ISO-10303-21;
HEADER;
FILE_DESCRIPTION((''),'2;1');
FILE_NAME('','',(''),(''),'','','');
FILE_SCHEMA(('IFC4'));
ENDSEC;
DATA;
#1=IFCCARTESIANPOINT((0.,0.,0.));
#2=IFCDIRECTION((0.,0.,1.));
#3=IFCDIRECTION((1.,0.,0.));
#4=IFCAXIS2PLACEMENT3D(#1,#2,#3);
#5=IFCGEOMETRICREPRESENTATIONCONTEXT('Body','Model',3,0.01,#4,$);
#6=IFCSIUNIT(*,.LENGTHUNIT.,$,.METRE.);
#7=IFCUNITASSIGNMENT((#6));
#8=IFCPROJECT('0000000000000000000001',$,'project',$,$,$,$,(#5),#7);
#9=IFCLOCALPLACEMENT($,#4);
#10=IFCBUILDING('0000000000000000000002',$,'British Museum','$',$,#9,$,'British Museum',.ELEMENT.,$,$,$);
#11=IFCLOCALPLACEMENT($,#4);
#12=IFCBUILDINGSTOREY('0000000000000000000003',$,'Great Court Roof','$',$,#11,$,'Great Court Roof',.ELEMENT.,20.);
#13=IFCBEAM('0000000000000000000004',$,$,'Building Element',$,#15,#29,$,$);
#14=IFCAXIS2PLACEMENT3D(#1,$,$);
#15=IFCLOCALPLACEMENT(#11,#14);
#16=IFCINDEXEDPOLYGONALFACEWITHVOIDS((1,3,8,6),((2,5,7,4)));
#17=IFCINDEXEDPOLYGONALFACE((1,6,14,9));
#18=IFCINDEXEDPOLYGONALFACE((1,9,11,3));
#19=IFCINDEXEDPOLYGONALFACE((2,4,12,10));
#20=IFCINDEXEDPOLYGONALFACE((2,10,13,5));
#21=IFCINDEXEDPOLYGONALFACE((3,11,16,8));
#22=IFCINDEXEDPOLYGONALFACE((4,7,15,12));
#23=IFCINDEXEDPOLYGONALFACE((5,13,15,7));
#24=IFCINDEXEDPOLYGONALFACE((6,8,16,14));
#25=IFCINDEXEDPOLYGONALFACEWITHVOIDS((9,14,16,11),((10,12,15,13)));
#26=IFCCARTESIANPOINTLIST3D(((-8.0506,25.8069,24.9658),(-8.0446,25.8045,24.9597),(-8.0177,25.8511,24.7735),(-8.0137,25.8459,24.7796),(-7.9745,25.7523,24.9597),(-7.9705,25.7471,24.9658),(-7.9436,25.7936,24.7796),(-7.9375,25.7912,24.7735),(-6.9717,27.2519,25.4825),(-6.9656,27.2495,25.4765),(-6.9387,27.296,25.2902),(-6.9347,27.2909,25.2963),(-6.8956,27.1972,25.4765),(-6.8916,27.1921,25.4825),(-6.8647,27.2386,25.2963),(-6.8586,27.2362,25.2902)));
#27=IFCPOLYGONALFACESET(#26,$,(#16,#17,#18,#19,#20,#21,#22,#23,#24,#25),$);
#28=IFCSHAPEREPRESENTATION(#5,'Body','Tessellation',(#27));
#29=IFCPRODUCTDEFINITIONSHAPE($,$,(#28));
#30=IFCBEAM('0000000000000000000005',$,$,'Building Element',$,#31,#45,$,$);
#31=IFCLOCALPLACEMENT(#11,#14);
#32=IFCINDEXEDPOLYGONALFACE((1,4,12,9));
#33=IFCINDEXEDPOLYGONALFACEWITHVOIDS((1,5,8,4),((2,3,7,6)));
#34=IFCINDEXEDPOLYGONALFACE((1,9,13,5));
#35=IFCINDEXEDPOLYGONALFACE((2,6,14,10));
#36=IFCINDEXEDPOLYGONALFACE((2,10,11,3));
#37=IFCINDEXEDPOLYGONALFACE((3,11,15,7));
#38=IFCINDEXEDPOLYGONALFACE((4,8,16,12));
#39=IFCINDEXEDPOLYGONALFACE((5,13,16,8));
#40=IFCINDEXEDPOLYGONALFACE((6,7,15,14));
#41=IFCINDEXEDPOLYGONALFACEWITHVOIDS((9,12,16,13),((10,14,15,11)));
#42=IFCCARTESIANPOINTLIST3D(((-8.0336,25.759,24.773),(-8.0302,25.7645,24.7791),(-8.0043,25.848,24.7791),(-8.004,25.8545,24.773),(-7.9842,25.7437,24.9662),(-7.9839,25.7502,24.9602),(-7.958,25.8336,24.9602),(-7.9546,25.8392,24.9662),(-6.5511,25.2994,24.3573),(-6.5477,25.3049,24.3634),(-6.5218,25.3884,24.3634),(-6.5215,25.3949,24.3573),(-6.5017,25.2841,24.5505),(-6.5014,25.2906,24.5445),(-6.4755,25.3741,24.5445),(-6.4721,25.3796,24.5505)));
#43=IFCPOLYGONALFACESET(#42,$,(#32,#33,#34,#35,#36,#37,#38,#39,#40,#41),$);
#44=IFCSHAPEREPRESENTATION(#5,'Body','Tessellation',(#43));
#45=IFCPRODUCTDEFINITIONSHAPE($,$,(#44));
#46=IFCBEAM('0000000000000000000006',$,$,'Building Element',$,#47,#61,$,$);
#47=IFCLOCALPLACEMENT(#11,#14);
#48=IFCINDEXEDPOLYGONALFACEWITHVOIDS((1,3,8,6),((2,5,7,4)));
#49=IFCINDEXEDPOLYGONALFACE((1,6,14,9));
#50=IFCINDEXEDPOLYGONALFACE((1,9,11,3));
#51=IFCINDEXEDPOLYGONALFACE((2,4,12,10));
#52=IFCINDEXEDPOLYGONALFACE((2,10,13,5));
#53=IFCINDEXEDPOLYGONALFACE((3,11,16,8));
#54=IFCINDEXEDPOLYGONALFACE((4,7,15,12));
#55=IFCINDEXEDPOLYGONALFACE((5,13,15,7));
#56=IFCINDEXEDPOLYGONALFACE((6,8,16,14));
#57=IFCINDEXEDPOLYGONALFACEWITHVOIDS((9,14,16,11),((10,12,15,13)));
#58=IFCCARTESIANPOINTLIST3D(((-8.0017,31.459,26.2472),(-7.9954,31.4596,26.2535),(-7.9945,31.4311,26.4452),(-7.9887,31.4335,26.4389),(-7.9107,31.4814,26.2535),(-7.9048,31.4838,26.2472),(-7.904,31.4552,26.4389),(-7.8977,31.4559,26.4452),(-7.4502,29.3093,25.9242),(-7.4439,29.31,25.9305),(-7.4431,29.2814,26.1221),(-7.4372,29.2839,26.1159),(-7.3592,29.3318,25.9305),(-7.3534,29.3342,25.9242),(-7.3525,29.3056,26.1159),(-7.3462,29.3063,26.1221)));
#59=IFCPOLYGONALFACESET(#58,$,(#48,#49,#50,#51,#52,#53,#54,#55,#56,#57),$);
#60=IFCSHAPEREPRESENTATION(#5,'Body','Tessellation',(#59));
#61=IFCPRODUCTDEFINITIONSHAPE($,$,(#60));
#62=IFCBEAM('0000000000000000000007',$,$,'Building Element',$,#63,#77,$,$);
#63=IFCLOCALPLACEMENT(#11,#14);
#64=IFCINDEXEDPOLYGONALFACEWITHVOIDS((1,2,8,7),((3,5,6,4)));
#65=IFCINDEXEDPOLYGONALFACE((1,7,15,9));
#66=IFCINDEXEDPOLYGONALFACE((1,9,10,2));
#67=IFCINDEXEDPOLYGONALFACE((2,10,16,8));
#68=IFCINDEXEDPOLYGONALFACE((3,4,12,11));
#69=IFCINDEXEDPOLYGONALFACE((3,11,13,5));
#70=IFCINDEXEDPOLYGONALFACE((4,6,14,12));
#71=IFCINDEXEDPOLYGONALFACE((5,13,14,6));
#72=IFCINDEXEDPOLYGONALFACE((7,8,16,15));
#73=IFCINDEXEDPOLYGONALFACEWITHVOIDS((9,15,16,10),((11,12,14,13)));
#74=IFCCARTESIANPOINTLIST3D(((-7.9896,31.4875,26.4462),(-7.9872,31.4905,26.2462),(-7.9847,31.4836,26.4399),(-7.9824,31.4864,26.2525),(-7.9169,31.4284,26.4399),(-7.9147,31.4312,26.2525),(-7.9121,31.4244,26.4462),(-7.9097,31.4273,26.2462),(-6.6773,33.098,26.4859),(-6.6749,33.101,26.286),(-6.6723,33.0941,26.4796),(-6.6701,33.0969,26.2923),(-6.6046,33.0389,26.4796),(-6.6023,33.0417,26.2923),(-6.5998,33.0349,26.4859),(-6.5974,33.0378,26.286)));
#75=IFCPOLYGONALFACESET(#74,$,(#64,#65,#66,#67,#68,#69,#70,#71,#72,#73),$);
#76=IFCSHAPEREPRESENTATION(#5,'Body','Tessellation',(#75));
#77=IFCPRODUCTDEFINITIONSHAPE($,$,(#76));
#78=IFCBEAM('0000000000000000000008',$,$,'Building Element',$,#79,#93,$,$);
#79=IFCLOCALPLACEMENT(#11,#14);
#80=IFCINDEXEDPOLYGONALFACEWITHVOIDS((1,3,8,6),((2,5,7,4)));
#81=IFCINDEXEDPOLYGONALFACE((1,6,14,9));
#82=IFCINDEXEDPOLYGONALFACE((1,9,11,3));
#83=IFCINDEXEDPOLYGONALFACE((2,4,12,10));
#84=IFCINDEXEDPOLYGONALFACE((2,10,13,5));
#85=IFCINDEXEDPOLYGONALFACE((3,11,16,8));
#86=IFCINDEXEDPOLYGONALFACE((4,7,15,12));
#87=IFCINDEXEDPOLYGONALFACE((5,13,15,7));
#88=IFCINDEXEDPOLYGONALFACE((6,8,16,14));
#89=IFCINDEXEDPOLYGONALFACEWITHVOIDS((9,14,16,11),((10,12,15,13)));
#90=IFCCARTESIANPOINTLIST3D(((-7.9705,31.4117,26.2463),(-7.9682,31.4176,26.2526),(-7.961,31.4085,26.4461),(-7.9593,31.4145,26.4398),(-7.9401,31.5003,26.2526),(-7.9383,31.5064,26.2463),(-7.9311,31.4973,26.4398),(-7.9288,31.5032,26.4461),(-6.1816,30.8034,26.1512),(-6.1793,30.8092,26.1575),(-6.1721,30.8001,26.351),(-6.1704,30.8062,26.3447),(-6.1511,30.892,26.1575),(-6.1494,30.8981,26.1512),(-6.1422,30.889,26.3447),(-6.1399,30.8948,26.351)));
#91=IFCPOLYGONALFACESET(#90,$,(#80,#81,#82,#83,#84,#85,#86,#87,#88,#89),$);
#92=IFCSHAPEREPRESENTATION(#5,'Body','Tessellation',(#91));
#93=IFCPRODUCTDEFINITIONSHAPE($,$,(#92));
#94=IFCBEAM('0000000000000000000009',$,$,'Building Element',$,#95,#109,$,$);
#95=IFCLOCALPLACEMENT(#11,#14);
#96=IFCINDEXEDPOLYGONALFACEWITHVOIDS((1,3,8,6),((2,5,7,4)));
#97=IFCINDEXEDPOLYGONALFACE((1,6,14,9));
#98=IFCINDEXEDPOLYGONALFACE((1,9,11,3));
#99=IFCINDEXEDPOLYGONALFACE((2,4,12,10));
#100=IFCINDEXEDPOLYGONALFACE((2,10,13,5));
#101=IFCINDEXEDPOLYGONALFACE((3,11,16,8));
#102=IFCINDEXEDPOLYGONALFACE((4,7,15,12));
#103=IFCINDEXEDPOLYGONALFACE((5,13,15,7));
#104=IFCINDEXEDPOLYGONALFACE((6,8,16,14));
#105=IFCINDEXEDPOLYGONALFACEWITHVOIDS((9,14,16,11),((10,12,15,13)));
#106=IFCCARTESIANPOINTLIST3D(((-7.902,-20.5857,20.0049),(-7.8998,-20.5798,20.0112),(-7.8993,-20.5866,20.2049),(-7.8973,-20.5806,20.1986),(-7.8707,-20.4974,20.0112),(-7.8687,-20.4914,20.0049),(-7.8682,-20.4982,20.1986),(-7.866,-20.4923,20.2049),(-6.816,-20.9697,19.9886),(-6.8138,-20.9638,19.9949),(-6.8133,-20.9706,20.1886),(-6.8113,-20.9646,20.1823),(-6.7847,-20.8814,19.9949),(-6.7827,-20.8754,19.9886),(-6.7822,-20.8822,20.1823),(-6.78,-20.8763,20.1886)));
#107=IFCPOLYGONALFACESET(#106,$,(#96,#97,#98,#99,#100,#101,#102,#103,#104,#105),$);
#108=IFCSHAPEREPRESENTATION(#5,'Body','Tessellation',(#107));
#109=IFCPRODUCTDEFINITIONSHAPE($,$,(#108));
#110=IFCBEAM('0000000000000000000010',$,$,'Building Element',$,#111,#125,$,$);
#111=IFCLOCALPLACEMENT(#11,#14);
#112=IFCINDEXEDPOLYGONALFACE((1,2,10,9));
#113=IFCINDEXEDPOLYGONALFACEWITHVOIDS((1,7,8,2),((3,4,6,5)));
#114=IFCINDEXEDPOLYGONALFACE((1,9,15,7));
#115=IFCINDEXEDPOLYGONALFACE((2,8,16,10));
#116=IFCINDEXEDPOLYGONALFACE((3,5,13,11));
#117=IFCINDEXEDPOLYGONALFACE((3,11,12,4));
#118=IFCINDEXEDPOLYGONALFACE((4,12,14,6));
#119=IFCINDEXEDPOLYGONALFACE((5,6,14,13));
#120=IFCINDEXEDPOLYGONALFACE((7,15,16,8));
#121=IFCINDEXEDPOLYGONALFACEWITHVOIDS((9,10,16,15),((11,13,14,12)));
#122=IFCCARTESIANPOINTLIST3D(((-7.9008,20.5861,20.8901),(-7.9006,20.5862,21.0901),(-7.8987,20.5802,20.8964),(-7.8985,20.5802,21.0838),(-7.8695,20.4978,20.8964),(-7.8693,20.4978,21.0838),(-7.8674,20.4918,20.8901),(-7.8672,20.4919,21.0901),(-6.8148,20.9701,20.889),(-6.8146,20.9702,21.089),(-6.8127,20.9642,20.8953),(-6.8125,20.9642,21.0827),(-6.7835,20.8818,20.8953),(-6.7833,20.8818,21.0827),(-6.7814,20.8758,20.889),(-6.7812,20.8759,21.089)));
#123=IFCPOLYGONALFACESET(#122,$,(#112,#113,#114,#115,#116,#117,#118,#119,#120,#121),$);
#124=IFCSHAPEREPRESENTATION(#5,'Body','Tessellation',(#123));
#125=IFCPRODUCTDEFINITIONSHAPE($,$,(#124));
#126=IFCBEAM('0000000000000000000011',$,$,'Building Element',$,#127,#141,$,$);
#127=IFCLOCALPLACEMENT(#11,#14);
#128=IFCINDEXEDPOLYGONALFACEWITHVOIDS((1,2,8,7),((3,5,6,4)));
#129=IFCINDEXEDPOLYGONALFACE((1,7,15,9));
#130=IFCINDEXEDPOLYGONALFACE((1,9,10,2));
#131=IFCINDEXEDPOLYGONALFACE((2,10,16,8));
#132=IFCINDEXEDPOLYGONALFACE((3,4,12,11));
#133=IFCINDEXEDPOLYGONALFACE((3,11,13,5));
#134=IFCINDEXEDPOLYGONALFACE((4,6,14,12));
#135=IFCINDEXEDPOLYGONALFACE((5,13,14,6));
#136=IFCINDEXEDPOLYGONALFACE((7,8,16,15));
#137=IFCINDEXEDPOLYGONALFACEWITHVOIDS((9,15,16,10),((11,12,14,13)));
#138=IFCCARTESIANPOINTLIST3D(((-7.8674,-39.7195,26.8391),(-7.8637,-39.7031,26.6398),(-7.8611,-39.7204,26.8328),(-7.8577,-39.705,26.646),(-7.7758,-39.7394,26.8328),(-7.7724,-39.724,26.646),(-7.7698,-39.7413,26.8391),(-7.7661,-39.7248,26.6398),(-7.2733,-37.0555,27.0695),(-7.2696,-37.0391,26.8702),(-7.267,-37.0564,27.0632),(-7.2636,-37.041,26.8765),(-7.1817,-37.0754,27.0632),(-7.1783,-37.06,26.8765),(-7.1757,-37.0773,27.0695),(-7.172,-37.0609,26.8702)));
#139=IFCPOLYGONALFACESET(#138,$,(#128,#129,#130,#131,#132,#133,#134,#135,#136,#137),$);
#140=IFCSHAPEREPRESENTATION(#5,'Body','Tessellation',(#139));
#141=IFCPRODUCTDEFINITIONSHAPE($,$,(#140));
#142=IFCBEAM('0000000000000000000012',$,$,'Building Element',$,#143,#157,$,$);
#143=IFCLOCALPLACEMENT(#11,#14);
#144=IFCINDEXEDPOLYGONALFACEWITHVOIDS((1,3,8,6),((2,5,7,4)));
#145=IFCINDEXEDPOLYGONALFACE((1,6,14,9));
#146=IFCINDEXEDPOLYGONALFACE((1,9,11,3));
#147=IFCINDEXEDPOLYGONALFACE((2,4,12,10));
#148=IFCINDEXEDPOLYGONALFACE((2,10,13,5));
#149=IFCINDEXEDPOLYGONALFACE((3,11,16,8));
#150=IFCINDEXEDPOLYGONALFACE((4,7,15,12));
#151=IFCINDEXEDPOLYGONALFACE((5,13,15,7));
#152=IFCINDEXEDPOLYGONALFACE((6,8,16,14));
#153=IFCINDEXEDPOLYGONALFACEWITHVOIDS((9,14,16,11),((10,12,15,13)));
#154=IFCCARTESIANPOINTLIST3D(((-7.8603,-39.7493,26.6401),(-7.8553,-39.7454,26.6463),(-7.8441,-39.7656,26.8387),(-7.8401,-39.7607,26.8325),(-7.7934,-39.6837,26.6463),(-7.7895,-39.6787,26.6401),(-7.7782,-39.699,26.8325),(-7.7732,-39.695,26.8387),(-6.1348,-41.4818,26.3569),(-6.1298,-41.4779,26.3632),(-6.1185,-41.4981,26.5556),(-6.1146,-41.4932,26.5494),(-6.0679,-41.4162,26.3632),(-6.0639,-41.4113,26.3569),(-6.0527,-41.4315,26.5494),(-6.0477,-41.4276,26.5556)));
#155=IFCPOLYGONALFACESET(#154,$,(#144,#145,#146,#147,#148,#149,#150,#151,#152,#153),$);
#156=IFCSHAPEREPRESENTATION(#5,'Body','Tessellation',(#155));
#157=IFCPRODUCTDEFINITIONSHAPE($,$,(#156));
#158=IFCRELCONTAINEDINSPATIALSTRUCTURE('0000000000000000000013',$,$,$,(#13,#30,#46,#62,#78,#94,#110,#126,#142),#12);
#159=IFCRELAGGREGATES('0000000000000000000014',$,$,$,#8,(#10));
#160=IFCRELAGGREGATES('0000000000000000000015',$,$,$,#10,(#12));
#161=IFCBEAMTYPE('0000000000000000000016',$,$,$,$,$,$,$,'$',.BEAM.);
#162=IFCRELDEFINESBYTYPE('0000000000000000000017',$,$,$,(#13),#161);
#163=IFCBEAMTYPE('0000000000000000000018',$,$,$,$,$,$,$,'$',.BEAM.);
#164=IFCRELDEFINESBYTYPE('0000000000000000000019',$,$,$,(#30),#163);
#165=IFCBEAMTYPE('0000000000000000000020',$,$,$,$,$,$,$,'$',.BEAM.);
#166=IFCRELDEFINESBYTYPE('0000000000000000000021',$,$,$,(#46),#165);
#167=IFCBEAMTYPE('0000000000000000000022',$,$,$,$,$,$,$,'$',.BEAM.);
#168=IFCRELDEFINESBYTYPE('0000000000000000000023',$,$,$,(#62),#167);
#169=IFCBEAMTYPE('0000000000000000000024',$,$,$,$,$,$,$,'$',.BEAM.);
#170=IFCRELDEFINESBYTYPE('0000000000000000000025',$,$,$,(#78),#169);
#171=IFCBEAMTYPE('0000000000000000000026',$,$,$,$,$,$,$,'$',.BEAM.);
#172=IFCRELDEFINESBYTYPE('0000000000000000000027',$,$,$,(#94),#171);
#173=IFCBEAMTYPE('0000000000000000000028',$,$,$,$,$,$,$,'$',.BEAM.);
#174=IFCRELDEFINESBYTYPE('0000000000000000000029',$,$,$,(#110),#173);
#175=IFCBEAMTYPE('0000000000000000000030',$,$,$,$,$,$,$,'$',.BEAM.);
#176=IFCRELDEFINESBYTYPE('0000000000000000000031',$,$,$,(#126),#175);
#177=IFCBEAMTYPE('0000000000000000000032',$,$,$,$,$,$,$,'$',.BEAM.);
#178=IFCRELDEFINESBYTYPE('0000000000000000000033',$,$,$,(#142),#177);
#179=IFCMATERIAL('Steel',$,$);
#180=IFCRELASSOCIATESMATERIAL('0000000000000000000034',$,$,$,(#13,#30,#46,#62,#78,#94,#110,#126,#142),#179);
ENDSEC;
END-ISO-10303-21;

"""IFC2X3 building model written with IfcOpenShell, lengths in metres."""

from ifc_helpers import new_model, si_unit, frame, origin_with_axes, origin_2d, place, context, project, spatial, hollow_rectangle, extrude, material, type_object, element, save


model = new_model("IFC2X3")

# Units and contexts
model_context = context("Model", 3, precision=0.01, world=origin_with_axes(), identifier="Body")
ifc_project = project(units=[si_unit("LENGTHUNIT", "METRE")], contexts=[model_context])

# Building, storey
building_placement = place(None, origin_with_axes())
building = spatial("IfcBuilding", under=ifc_project, at=building_placement, Name="British Museum", Description="$", LongName="British Museum", CompositionType="ELEMENT")
storey_placement = place(None, origin_with_axes())
storey = spatial("IfcBuildingStorey", under=building, at=storey_placement, Name="Great Court Roof", Description="$", LongName="Great Court Roof", CompositionType="ELEMENT", Elevation=20.0)

# Beams
ifc_material = material(Name="Steel")
beam_type_1 = type_object("IfcBeamType", ElementType="$", PredefinedType="BEAM")
beam_1_placement = place(None, origin_with_axes())
element("IfcBeam", 1, at=beam_1_placement, inside=storey, type_object=beam_type_1, material=ifc_material, Description="Building Element", context=model_context, shape_type="SweptSolid", body=[
    extrude(hollow_rectangle(XDim=0.1, YDim=0.2, WallThickness=0.0063, InnerFilletRadius=-0.0063, OuterFilletRadius=0.0, at=origin_2d()), frame((-7.9941, 25.7991, 24.8696), z_axis=(0.575161, 0.770269, 0.275455), x_axis=(-0.801267, 0.598307, 0.0)), (0.0, 0.0, 1.0), 1.8759),
])
beam_type_2 = type_object("IfcBeamType", ElementType="$", PredefinedType="BEAM")
beam_2_placement = place(None, origin_with_axes())
element("IfcBeam", 2, at=beam_2_placement, inside=storey, type_object=beam_type_2, material=ifc_material, Description="Building Element", context=model_context, shape_type="SweptSolid", body=[
    extrude(hollow_rectangle(XDim=0.1, YDim=0.2, WallThickness=0.0063, InnerFilletRadius=-0.0063, OuterFilletRadius=0.0, at=origin_2d()), frame((-7.9941, 25.7991, 24.8696), z_axis=(0.922636, -0.286024, -0.258716), x_axis=(0.296105, 0.955155, 0.0)), (0.0, 0.0, 1.0), 1.6068),
])
beam_type_3 = type_object("IfcBeamType", ElementType="$", PredefinedType="BEAM")
beam_3_placement = place(None, origin_with_axes())
element("IfcBeam", 3, at=beam_3_placement, inside=storey, type_object=beam_type_3, material=ifc_material, Description="Building Element", context=model_context, shape_type="SweptSolid", body=[
    extrude(hollow_rectangle(XDim=0.1, YDim=0.2, WallThickness=0.0063, InnerFilletRadius=-0.0063, OuterFilletRadius=0.0, at=origin_2d()), frame((-7.9497, 31.4574, 26.3462), z_axis=(0.245904, -0.958533, -0.144035), x_axis=(0.968633, 0.248495, 0.0)), (0.0, 0.0, 1.0), 2.2426),
])
beam_type_4 = type_object("IfcBeamType", ElementType="$", PredefinedType="BEAM")
beam_4_placement = place(None, origin_with_axes())
element("IfcBeam", 4, at=beam_4_placement, inside=storey, type_object=beam_type_4, material=ifc_material, Description="Building Element", context=model_context, shape_type="SweptSolid", body=[
    extrude(hollow_rectangle(XDim=0.1, YDim=0.2, WallThickness=0.0063, InnerFilletRadius=-0.0063, OuterFilletRadius=0.0, at=origin_2d()), frame((-7.9497, 31.4574, 26.3462), z_axis=(0.631586, 0.77507, 0.019136), x_axis=(-0.775212, 0.631702, 0.0)), (0.0, 0.0, 1.0), 2.0779),
])
beam_type_5 = type_object("IfcBeamType", ElementType="$", PredefinedType="BEAM")
beam_5_placement = place(None, origin_with_axes())
element("IfcBeam", 5, at=beam_5_placement, inside=storey, type_object=beam_type_5, material=ifc_material, Description="Building Element", context=model_context, shape_type="SweptSolid", body=[
    extrude(hollow_rectangle(XDim=0.1, YDim=0.2, WallThickness=0.0063, InnerFilletRadius=-0.0063, OuterFilletRadius=0.0, at=origin_2d()), frame((-7.9497, 31.4574, 26.3462), z_axis=(0.945559, -0.321544, -0.050273), x_axis=(0.321951, 0.946756, 0.0)), (0.0, 0.0, 1.0), 1.8919),
])
beam_type_6 = type_object("IfcBeamType", ElementType="$", PredefinedType="BEAM")
beam_6_placement = place(None, origin_with_axes())
element("IfcBeam", 6, at=beam_6_placement, inside=storey, type_object=beam_type_6, material=ifc_material, Description="Building Element", context=model_context, shape_type="SweptSolid", body=[
    extrude(hollow_rectangle(XDim=0.1, YDim=0.2, WallThickness=0.0063, InnerFilletRadius=-0.0063, OuterFilletRadius=0.0, at=origin_2d()), frame((-7.884, -20.539, 20.1049), z_axis=(0.942703, -0.333332, -0.014167), x_axis=(0.333365, 0.942798, 0.0)), (0.0, 0.0, 1.0), 1.152),
])
beam_type_7 = type_object("IfcBeamType", ElementType="$", PredefinedType="BEAM")
beam_7_placement = place(None, origin_with_axes())
element("IfcBeam", 7, at=beam_7_placement, inside=storey, type_object=beam_type_7, material=ifc_material, Description="Building Element", context=model_context, shape_type="SweptSolid", body=[
    extrude(hollow_rectangle(XDim=0.1, YDim=0.2, WallThickness=0.0063, InnerFilletRadius=-0.0063, OuterFilletRadius=0.0, at=origin_2d()), frame((-7.884, 20.539, 20.9901), z_axis=(0.942797, 0.333365, -0.000967), x_axis=(-0.333365, 0.942798, 0.0)), (0.0, 0.0, 1.0), 1.1519),
])
beam_type_8 = type_object("IfcBeamType", ElementType="$", PredefinedType="BEAM")
beam_8_placement = place(None, origin_with_axes())
element("IfcBeam", 8, at=beam_8_placement, inside=storey, type_object=beam_type_8, material=ifc_material, Description="Building Element", context=model_context, shape_type="SweptSolid", body=[
    extrude(hollow_rectangle(XDim=0.1, YDim=0.2, WallThickness=0.0063, InnerFilletRadius=-0.0063, OuterFilletRadius=0.0, at=origin_2d()), frame((-7.8168, -39.7222, 26.7394), z_axis=(0.216898, 0.972561, 0.084138), x_axis=(-0.976022, 0.21767, 0.0)), (0.0, 0.0, 1.0), 2.7391),
])
beam_type_9 = type_object("IfcBeamType", ElementType="$", PredefinedType="BEAM")
beam_9_placement = place(None, origin_with_axes())
element("IfcBeam", 9, at=beam_9_placement, inside=storey, type_object=beam_type_9, material=ifc_material, Description="Building Element", context=model_context, shape_type="SweptSolid", body=[
    extrude(hollow_rectangle(XDim=0.1, YDim=0.2, WallThickness=0.0063, InnerFilletRadius=-0.0063, OuterFilletRadius=0.0, at=origin_2d()), frame((-7.8168, -39.7222, 26.7394), z_axis=(0.700991, -0.703834, -0.115019), x_axis=(0.708536, 0.705674, 0.0)), (0.0, 0.0, 1.0), 2.4616),
])

save(model, "model.ifc")
